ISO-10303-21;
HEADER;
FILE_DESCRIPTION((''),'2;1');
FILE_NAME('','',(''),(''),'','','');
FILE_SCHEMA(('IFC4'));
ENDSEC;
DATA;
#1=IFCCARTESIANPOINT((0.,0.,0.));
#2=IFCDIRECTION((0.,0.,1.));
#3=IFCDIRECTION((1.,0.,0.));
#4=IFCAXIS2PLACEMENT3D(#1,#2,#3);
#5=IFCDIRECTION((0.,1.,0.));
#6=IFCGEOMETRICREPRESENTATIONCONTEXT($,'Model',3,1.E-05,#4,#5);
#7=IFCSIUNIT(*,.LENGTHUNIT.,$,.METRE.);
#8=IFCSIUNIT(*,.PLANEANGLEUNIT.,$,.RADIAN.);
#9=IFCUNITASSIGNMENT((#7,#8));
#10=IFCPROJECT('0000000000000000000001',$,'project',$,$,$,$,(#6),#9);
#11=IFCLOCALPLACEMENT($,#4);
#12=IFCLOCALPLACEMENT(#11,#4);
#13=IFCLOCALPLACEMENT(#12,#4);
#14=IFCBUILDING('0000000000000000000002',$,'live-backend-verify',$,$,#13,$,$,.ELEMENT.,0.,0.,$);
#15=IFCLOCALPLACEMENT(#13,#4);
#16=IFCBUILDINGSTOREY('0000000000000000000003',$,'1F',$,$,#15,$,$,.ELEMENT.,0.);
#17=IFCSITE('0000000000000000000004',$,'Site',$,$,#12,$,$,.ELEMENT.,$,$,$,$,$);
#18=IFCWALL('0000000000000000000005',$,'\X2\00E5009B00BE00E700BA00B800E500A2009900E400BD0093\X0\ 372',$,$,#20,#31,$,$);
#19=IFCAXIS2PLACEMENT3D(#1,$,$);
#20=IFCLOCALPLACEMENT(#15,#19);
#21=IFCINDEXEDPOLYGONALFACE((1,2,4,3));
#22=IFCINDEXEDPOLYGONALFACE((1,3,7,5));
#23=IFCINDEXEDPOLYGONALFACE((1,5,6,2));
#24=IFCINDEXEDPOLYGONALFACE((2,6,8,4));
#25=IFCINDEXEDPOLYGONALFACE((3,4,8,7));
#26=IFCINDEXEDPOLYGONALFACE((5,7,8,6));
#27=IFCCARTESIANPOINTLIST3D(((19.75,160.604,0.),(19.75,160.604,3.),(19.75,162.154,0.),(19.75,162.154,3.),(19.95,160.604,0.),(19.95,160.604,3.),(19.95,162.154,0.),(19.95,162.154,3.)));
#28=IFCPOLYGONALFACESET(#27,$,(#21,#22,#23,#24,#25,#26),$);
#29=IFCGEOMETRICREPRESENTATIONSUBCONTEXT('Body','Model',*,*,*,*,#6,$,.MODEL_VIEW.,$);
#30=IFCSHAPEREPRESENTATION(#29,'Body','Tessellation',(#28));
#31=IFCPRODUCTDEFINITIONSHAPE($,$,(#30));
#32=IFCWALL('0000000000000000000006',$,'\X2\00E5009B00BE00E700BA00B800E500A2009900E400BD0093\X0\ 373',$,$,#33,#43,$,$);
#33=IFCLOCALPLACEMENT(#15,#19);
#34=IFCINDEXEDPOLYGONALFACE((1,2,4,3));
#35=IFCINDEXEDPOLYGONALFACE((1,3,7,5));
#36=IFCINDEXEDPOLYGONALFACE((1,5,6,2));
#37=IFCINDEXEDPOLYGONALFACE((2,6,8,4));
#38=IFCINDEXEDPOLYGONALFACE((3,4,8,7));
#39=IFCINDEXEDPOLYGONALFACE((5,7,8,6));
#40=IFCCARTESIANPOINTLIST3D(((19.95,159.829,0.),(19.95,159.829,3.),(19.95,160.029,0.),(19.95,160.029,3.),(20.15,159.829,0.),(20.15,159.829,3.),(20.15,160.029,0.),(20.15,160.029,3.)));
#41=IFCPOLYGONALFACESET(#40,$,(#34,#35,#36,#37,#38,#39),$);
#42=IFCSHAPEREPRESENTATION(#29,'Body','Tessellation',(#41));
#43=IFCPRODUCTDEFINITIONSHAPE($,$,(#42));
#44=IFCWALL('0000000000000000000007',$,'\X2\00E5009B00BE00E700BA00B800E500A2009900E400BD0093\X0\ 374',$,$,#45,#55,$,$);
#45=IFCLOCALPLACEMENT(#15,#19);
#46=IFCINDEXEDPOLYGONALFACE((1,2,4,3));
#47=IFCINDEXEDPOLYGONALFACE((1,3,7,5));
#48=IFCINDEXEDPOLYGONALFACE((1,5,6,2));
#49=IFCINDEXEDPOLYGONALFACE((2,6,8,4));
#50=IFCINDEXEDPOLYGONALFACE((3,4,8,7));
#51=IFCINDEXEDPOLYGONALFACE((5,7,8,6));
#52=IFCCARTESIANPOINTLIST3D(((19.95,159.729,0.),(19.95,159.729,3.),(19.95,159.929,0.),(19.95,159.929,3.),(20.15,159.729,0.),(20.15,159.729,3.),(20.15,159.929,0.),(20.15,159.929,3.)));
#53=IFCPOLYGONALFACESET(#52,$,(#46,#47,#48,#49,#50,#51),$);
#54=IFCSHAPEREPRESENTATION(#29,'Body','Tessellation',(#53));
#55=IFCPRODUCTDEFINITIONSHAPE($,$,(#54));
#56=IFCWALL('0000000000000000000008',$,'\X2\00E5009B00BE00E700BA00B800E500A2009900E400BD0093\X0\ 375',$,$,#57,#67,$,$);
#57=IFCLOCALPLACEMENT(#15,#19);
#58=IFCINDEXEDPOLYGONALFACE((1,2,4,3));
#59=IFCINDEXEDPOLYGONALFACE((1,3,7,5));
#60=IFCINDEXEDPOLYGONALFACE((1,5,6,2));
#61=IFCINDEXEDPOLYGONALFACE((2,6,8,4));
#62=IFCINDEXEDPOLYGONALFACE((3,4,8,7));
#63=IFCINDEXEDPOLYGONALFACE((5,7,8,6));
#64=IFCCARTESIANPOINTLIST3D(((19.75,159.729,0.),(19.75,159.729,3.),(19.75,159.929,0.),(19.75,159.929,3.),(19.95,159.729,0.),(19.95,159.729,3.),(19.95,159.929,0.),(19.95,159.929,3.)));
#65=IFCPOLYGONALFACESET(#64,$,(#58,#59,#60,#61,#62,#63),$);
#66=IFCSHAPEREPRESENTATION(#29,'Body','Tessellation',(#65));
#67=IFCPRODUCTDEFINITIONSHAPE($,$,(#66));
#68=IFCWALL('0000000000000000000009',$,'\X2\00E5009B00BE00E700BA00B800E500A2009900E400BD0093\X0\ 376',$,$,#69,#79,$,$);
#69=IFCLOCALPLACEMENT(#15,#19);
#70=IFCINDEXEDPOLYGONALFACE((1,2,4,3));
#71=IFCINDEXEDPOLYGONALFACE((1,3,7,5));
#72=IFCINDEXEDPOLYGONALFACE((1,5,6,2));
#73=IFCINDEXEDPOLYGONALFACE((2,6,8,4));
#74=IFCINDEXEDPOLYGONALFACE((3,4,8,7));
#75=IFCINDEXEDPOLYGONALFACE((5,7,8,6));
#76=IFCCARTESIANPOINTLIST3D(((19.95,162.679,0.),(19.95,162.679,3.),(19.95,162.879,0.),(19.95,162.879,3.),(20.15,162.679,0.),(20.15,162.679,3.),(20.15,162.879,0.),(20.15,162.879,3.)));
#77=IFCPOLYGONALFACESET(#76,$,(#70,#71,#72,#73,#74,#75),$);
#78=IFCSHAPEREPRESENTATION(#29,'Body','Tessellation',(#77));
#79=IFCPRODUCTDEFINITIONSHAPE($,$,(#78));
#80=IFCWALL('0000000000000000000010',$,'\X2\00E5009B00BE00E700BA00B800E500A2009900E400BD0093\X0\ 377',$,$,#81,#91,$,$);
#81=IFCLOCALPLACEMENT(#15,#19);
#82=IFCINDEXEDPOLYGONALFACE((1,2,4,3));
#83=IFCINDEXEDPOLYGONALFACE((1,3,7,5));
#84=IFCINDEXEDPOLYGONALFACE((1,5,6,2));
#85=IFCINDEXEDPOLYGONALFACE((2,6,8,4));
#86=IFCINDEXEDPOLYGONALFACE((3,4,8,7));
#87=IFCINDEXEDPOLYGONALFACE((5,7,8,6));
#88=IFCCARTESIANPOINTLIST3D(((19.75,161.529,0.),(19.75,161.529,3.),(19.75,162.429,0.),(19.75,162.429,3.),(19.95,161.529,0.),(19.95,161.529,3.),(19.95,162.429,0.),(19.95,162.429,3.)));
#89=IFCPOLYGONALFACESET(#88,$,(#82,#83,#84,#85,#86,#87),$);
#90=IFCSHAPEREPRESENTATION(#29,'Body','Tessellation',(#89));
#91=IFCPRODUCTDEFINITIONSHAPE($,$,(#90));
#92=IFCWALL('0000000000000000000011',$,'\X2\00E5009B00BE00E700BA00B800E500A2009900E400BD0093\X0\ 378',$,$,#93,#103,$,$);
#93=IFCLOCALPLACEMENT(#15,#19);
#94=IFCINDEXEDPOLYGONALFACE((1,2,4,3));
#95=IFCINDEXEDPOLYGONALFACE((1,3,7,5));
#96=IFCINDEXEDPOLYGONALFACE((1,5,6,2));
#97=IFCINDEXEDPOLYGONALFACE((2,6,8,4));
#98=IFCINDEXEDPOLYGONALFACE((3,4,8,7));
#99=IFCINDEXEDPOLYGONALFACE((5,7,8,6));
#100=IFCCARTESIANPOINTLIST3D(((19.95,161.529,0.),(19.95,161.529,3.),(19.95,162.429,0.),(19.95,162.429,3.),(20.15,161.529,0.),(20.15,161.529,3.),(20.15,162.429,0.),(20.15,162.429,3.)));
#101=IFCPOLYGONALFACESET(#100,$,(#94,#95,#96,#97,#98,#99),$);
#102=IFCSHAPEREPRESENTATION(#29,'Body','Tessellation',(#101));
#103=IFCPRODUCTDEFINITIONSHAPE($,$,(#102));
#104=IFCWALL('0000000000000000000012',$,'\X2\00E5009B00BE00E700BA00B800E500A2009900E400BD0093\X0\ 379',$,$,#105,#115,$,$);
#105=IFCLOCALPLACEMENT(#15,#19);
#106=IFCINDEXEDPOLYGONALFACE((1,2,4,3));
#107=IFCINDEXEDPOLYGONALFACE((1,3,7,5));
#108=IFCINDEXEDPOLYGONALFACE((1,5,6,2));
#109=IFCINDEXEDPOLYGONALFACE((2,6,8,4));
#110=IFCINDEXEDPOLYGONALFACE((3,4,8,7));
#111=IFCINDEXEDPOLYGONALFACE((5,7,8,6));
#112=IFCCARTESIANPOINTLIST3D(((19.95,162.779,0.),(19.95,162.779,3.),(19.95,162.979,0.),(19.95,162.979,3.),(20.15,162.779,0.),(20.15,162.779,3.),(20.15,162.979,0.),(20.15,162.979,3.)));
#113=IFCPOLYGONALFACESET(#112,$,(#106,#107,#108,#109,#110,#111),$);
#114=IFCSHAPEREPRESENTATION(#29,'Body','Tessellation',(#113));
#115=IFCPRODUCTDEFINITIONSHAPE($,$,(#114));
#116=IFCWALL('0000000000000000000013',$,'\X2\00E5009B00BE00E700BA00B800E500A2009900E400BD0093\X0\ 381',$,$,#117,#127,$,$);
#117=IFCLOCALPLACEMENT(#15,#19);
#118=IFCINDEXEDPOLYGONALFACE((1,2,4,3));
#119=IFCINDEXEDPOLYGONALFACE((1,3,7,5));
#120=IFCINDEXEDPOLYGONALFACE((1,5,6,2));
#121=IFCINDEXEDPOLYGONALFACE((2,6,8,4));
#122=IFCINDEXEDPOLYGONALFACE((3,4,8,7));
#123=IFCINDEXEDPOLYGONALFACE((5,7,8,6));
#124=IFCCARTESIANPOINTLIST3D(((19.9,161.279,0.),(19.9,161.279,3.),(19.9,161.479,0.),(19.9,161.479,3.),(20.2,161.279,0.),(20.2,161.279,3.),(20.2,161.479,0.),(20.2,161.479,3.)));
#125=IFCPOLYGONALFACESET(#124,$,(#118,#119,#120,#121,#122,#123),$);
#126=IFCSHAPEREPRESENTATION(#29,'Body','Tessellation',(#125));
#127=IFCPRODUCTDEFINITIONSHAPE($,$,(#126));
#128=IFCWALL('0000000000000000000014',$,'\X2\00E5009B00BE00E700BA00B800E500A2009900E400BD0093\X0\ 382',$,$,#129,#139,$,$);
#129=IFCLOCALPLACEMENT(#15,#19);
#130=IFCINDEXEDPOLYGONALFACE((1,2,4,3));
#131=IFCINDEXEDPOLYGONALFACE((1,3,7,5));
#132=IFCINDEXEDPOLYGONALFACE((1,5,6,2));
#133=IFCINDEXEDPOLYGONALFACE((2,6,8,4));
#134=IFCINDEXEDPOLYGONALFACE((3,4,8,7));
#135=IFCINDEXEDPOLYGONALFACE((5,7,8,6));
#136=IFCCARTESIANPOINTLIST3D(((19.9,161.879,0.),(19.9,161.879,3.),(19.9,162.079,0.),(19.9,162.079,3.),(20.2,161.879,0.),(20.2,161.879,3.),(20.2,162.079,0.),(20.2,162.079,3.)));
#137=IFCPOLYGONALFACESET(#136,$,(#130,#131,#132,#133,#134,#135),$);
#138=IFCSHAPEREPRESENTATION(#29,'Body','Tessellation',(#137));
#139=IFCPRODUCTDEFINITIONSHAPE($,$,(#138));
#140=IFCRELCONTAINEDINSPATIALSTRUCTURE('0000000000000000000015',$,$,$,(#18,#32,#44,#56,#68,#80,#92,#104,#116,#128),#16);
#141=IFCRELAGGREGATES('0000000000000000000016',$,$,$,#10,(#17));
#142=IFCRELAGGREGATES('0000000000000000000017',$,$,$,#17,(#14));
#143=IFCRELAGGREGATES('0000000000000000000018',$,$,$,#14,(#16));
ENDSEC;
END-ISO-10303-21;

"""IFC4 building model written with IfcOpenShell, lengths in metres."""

from ifc_helpers import new_model, si_unit, direction, frame, frame_2d, origin_with_axes, place, context, subcontext, project, spatial, rectangle, extrude, element, save


model = new_model("IFC4")

# Units and contexts
model_context = context("Model", 3, precision=1e-05, world=origin_with_axes(), true_north=direction((0.0, 1.0, 0.0)))
body_context = subcontext(model_context, "Body", "Model", "MODEL_VIEW")
ifc_project = project(units=[si_unit("LENGTHUNIT", "METRE"), si_unit("PLANEANGLEUNIT", "RADIAN")], contexts=[model_context])

# Site, building, storey
placement = place(None, origin_with_axes())
site_placement = place(placement, origin_with_axes())
site = spatial("IfcSite", under=ifc_project, at=site_placement, Name="Site", CompositionType="ELEMENT")
building_placement = place(site_placement, origin_with_axes())
building = spatial("IfcBuilding", under=site, at=building_placement, Name="live-backend-verify", CompositionType="ELEMENT", ElevationOfRefHeight=0.0, ElevationOfTerrain=0.0)
storey_placement = place(building_placement, origin_with_axes())
storey = spatial("IfcBuildingStorey", under=building, at=storey_placement, Name="1F", CompositionType="ELEMENT", Elevation=0.0)

# Walls
wall_1_placement = place(storey_placement, frame((19.85, 161.379, 0.0), z_axis=(0.0, 0.0, 1.0), x_axis=(0.0, -1.0, 0.0)))
element("IfcWall", 1, at=wall_1_placement, inside=storey, Name="å\u009b¾çº¸å¢\u0099ä½\u0093 372", context=body_context, shape_type="SweptSolid", body=[
    extrude(rectangle(XDim=1.55, YDim=0.2, at=frame_2d((0.0, 0.0), x_axis=(1.0, 0.0, 0.0))), frame((0.0, 0.0, 0.0), z_axis=(0.0, 0.0, 1.0)), (0.0, 0.0, 1.0), 3.0),
])
for number, where, z_axis, x_axis, name in (
    (2, (20.05, 159.929, 0.0), (0.0, 0.0, 1.0), (-1.0, 0.0, 0.0), "å\u009b¾çº¸å¢\u0099ä½\u0093 373"),
    (3, (20.05, 159.829, 0.0), (0.0, 0.0, 1.0), (-1.0, 0.0, 0.0), "å\u009b¾çº¸å¢\u0099ä½\u0093 374"),
    (4, (19.85, 159.829, 0.0), (0.0, 0.0, 1.0), (1.0, 0.0, 0.0), "å\u009b¾çº¸å¢\u0099ä½\u0093 375"),
    (5, (20.05, 162.779, 0.0), (0.0, 0.0, 1.0), (-1.0, 0.0, 0.0), "å\u009b¾çº¸å¢\u0099ä½\u0093 376"),
):
    element("IfcWall", number, at=place(storey_placement, frame(where, z_axis=z_axis, x_axis=x_axis)), inside=storey, Name=name, context=body_context, shape_type="SweptSolid", body=[
        extrude(rectangle(XDim=0.2, YDim=0.2, at=frame_2d((0.0, 0.0), x_axis=(1.0, 0.0, 0.0))), frame((0.0, 0.0, 0.0), z_axis=(0.0, 0.0, 1.0)), (0.0, 0.0, 1.0), 3.0),
    ])
for number, where, z_axis, x_axis, name in (
    (6, (19.85, 161.979, 0.0), (0.0, 0.0, 1.0), (0.0, 1.0, 0.0), "å\u009b¾çº¸å¢\u0099ä½\u0093 377"),
    (7, (20.05, 161.979, 0.0), (0.0, 0.0, 1.0), (0.0, 1.0, 0.0), "å\u009b¾çº¸å¢\u0099ä½\u0093 378"),
):
    element("IfcWall", number, at=place(storey_placement, frame(where, z_axis=z_axis, x_axis=x_axis)), inside=storey, Name=name, context=body_context, shape_type="SweptSolid", body=[
        extrude(rectangle(XDim=0.9, YDim=0.2, at=frame_2d((0.0, 0.0), x_axis=(1.0, 0.0, 0.0))), frame((0.0, 0.0, 0.0), z_axis=(0.0, 0.0, 1.0)), (0.0, 0.0, 1.0), 3.0),
    ])
wall_2_placement = place(storey_placement, frame((20.05, 162.879, 0.0), z_axis=(0.0, 0.0, 1.0), x_axis=(-1.0, 0.0, 0.0)))
element("IfcWall", 8, at=wall_2_placement, inside=storey, Name="å\u009b¾çº¸å¢\u0099ä½\u0093 379", context=body_context, shape_type="SweptSolid", body=[
    extrude(rectangle(XDim=0.2, YDim=0.2, at=frame_2d((0.0, 0.0), x_axis=(1.0, 0.0, 0.0))), frame((0.0, 0.0, 0.0), z_axis=(0.0, 0.0, 1.0)), (0.0, 0.0, 1.0), 3.0),
])
for number, where, z_axis, x_axis, name in (
    (9, (20.05, 161.379, 0.0), (0.0, 0.0, 1.0), (-1.0, 0.0, 0.0), "å\u009b¾çº¸å¢\u0099ä½\u0093 381"),
    (10, (20.05, 161.979, 0.0), (0.0, 0.0, 1.0), (-1.0, 0.0, 0.0), "å\u009b¾çº¸å¢\u0099ä½\u0093 382"),
):
    element("IfcWall", number, at=place(storey_placement, frame(where, z_axis=z_axis, x_axis=x_axis)), inside=storey, Name=name, context=body_context, shape_type="SweptSolid", body=[
        extrude(rectangle(XDim=0.3, YDim=0.2, at=frame_2d((0.0, 0.0), x_axis=(1.0, 0.0, 0.0))), frame((0.0, 0.0, 0.0), z_axis=(0.0, 0.0, 1.0)), (0.0, 0.0, 1.0), 3.0),
    ])

save(model, "model.ifc")
